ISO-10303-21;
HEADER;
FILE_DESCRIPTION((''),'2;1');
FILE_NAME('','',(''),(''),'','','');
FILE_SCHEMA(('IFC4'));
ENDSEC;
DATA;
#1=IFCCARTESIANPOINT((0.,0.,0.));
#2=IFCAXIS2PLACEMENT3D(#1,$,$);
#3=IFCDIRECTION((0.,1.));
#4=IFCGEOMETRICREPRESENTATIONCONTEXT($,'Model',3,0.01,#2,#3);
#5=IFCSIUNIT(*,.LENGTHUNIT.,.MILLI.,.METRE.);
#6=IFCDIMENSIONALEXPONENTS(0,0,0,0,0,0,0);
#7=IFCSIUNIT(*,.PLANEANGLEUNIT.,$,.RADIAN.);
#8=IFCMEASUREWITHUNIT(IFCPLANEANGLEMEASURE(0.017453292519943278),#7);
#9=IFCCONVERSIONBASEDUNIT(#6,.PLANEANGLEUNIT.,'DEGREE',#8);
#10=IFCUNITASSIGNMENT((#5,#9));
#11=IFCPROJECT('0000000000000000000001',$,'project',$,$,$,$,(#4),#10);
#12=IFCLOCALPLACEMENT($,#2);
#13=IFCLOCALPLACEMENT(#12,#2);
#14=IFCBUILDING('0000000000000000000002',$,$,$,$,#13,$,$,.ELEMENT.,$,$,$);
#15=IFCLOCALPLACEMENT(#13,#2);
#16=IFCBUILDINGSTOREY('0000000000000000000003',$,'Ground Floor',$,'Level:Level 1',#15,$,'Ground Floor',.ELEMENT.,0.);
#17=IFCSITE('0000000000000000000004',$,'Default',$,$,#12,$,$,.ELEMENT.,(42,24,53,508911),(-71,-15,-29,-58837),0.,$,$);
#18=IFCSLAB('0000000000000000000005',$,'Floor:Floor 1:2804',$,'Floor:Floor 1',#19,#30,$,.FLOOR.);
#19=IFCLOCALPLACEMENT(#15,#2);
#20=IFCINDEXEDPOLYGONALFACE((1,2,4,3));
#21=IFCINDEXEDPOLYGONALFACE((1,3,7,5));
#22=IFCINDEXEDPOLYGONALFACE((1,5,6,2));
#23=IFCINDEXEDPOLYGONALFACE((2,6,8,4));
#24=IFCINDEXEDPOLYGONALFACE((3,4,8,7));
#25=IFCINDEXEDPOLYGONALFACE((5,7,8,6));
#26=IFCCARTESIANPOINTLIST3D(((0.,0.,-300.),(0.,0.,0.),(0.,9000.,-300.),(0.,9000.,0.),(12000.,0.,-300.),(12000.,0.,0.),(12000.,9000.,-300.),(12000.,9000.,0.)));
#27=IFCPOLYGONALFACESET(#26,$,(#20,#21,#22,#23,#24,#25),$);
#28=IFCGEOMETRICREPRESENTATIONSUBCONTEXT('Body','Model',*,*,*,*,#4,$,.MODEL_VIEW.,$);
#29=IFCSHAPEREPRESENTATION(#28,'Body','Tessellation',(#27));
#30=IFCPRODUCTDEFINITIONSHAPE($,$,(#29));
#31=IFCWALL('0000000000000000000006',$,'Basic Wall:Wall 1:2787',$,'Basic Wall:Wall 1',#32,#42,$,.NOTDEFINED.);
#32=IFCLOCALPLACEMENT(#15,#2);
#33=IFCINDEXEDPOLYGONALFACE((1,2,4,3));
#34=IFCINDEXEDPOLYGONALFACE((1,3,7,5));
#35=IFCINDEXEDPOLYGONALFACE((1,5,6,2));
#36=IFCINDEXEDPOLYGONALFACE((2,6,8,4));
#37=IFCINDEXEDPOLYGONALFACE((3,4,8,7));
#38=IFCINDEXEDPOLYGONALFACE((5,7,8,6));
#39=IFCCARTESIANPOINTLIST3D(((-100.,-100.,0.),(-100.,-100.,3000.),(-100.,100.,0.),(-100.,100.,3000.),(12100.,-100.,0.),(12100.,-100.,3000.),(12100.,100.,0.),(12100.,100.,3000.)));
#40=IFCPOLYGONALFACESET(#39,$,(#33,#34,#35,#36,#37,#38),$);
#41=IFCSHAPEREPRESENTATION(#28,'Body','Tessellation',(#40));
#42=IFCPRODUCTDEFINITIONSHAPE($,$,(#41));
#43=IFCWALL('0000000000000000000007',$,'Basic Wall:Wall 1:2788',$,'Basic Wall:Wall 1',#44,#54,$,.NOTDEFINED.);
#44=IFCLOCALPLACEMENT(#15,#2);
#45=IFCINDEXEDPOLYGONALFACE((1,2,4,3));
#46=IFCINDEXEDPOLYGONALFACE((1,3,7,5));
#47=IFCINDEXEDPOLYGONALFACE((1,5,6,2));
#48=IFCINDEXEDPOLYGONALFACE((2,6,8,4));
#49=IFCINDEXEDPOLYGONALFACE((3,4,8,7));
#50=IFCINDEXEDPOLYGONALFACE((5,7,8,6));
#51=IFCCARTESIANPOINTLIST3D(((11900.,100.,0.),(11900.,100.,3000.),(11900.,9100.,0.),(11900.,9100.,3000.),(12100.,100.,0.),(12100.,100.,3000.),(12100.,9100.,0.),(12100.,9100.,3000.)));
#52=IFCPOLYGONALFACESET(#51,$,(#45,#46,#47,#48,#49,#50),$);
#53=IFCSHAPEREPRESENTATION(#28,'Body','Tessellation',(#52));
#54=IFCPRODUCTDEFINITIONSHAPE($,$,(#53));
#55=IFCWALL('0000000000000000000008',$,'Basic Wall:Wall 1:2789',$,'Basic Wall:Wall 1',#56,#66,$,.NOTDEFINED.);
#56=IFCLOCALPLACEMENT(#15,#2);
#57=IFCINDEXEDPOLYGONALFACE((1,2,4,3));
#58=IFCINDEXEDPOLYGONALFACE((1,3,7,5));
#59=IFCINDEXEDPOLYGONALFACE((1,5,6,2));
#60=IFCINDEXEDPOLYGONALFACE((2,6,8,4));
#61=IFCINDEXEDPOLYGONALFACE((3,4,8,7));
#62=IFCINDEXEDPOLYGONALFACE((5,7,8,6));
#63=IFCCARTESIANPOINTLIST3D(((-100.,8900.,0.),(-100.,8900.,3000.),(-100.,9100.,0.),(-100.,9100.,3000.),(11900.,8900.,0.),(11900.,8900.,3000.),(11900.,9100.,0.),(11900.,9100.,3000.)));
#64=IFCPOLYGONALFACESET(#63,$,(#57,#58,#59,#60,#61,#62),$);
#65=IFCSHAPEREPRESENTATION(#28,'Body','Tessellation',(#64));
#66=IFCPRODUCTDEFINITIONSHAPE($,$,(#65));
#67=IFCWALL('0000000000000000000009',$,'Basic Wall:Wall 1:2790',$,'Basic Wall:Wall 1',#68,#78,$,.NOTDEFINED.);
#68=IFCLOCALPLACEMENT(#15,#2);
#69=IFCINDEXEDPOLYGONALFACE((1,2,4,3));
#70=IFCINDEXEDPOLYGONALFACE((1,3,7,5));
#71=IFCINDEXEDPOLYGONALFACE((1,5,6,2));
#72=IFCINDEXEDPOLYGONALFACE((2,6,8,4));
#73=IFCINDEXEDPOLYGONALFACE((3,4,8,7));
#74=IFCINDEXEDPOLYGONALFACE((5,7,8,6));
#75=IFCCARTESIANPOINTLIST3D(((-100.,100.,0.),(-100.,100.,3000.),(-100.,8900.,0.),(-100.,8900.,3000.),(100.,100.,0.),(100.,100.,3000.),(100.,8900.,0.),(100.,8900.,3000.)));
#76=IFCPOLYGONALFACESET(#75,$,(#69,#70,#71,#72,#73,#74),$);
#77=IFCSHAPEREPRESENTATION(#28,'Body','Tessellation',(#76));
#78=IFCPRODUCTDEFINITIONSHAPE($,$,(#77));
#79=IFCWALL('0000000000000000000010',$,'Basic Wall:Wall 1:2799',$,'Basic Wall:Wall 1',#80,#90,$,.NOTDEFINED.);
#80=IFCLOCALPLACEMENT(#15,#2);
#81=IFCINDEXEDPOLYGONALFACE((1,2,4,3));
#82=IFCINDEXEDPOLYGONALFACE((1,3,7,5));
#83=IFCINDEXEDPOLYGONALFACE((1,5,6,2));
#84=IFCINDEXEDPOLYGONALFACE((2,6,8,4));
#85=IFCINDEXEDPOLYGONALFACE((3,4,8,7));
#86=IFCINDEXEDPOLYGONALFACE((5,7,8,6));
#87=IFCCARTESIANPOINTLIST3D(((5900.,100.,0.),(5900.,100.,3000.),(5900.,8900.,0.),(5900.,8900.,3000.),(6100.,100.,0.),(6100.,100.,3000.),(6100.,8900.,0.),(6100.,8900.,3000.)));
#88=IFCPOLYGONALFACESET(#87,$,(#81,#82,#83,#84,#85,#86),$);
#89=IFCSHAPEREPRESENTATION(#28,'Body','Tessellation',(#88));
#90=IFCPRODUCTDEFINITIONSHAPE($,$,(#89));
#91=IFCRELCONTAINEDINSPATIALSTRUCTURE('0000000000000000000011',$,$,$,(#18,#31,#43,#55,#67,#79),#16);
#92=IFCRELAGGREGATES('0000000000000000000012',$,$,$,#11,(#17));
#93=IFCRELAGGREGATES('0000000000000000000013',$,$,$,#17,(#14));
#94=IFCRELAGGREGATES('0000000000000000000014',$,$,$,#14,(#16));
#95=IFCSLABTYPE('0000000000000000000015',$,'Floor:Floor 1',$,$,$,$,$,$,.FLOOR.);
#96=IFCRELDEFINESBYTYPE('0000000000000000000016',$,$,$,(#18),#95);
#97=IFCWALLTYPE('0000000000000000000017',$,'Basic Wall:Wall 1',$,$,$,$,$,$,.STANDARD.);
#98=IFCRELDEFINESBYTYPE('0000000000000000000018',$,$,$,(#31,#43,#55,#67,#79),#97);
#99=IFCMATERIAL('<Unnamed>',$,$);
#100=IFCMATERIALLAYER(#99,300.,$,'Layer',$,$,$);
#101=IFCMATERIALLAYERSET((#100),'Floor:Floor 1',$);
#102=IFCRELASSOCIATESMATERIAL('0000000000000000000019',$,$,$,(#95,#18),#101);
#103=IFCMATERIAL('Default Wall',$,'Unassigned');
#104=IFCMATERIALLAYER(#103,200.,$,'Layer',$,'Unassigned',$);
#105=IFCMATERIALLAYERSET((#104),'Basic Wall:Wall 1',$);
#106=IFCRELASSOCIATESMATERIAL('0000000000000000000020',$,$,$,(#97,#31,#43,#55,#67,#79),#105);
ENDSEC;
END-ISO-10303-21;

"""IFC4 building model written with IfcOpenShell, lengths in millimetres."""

from ifc_helpers import new_model, entity, si_unit, converted_unit, direction, frame, frame_2d, origin, origin_2d_with_axis, place, context, subcontext, project, spatial, rectangle, extrude, material, layer, layer_set, layer_usage, type_object, element, save


model = new_model("IFC4")

# Units and contexts
model_context = context("Model", 3, precision=0.01, world=origin(), true_north=direction((0.0, 1.0)))
body_context = subcontext(model_context, "Body", "Model", "MODEL_VIEW")
ifc_project = project(units=[si_unit("LENGTHUNIT", "METRE", prefix="MILLI"), converted_unit("PLANEANGLEUNIT", "DEGREE", entity("IfcPlaneAngleMeasure", 0.017453292519943278), si_unit("PLANEANGLEUNIT", "RADIAN"), dimensions=[0, 0, 0, 0, 0, 0, 0])], contexts=[model_context])

# Site, building, storey
site_placement = place(None, origin())
site = spatial("IfcSite", under=ifc_project, at=site_placement, Name="Default", CompositionType="ELEMENT", RefLatitude=(42, 24, 53, 508911), RefLongitude=(-71, -15, -29, -58837), RefElevation=0.0)
building_placement = place(site_placement, origin())
building = spatial("IfcBuilding", under=site, at=building_placement, CompositionType="ELEMENT")
storey_placement = place(building_placement, origin())
storey = spatial("IfcBuildingStorey", under=building, at=storey_placement, Name="Ground Floor", ObjectType="Level:Level 1", LongName="Ground Floor", CompositionType="ELEMENT", Elevation=0.0)

# Slab
ifc_material_1 = material(Name="<Unnamed>")
ifc_layer_1 = layer(ifc_material_1, 300.0, Name="Layer")
ifc_layer_set_1 = layer_set([ifc_layer_1], Name="Floor:Floor 1")
ifc_layer_usage_1 = layer_usage(ifc_layer_set_1, "AXIS3", "POSITIVE", 0.0)
slab_type = type_object("IfcSlabType", Name="Floor:Floor 1", PredefinedType="FLOOR", material=ifc_layer_set_1)
slab_placement = place(storey_placement, origin())
element("IfcSlab", 1, at=slab_placement, inside=storey, type_object=slab_type, material=ifc_layer_usage_1, Name="Floor:Floor 1:2804", ObjectType="Floor:Floor 1", PredefinedType="FLOOR", context=body_context, shape_type="SweptSolid", body=[
    extrude(rectangle(XDim=9000.0, YDim=12000.0, at=origin_2d_with_axis()), frame((6000.0, 4500.0, 0.0), z_axis=(0.0, 0.0, -1.0), x_axis=(0.0, 1.0, 0.0)), (0.0, 0.0, 1.0), 300.0),
])

# Walls
ifc_material_2 = material(Name="Default Wall", Category="Unassigned")
ifc_layer_2 = layer(ifc_material_2, 200.0, Name="Layer", Category="Unassigned")
ifc_layer_set_2 = layer_set([ifc_layer_2], Name="Basic Wall:Wall 1")
ifc_layer_usage_2 = layer_usage(ifc_layer_set_2, "AXIS2", "NEGATIVE", 100.0)
wall_type = type_object("IfcWallType", Name="Basic Wall:Wall 1", PredefinedType="STANDARD", material=ifc_layer_set_2)
wall_1_placement = place(storey_placement, frame((-100.0, 0.0, 0.0)))
element("IfcWall", 2, at=wall_1_placement, inside=storey, type_object=wall_type, material=ifc_layer_usage_2, Name="Basic Wall:Wall 1:2787", ObjectType="Basic Wall:Wall 1", PredefinedType="NOTDEFINED", context=body_context, shape_type="SweptSolid", body=[
    extrude(rectangle(XDim=12200.0, YDim=200.0, at=frame_2d((6100.0, 0.0), x_axis=(-1.0, 0.0))), origin(), (0.0, 0.0, 1.0), 3000.0),
])
ifc_layer_usage_3 = layer_usage(ifc_layer_set_2, "AXIS2", "NEGATIVE", 100.0)
wall_2_placement = place(storey_placement, frame((12000.0, 100.0, 0.0), z_axis=(0.0, 0.0, 1.0), x_axis=(0.0, 1.0, 0.0)))
element("IfcWall", 3, at=wall_2_placement, inside=storey, type_object=wall_type, material=ifc_layer_usage_3, Name="Basic Wall:Wall 1:2788", ObjectType="Basic Wall:Wall 1", PredefinedType="NOTDEFINED", context=body_context, shape_type="SweptSolid", body=[
    extrude(rectangle(XDim=9000.0, YDim=200.0, at=frame_2d((4500.0, 0.0), x_axis=(-1.0, 0.0))), origin(), (0.0, 0.0, 1.0), 3000.0),
])
ifc_layer_usage_4 = layer_usage(ifc_layer_set_2, "AXIS2", "NEGATIVE", 100.0)
wall_3_placement = place(storey_placement, frame((11900.0, 9000.0, 0.0), z_axis=(0.0, 0.0, 1.0), x_axis=(-1.0, 0.0, 0.0)))
element("IfcWall", 4, at=wall_3_placement, inside=storey, type_object=wall_type, material=ifc_layer_usage_4, Name="Basic Wall:Wall 1:2789", ObjectType="Basic Wall:Wall 1", PredefinedType="NOTDEFINED", context=body_context, shape_type="SweptSolid", body=[
    extrude(rectangle(XDim=12000.0, YDim=200.0, at=frame_2d((6000.0, 0.0), x_axis=(-1.0, 0.0))), origin(), (0.0, 0.0, 1.0), 3000.0),
])
ifc_layer_usage_5 = layer_usage(ifc_layer_set_2, "AXIS2", "NEGATIVE", 100.0)
wall_4_placement = place(storey_placement, frame((0.0, 8900.0, 0.0), z_axis=(0.0, 0.0, 1.0), x_axis=(0.0, -1.0, 0.0)))
element("IfcWall", 5, at=wall_4_placement, inside=storey, type_object=wall_type, material=ifc_layer_usage_5, Name="Basic Wall:Wall 1:2790", ObjectType="Basic Wall:Wall 1", PredefinedType="NOTDEFINED", context=body_context, shape_type="SweptSolid", body=[
    extrude(rectangle(XDim=8800.0, YDim=200.0, at=frame_2d((4400.0, 0.0), x_axis=(-1.0, 0.0))), origin(), (0.0, 0.0, 1.0), 3000.0),
])
ifc_layer_usage_6 = layer_usage(ifc_layer_set_2, "AXIS2", "NEGATIVE", 100.0)
wall_5_placement = place(storey_placement, frame((6000.0, 100.0, 0.0), z_axis=(0.0, 0.0, 1.0), x_axis=(0.0, 1.0, 0.0)))
element("IfcWall", 6, at=wall_5_placement, inside=storey, type_object=wall_type, material=ifc_layer_usage_6, Name="Basic Wall:Wall 1:2799", ObjectType="Basic Wall:Wall 1", PredefinedType="NOTDEFINED", context=body_context, shape_type="SweptSolid", body=[
    extrude(rectangle(XDim=8800.0, YDim=200.0, at=frame_2d((4400.0, 0.0), x_axis=(-1.0, 0.0))), origin(), (0.0, 0.0, 1.0), 3000.0),
])

save(model, "model.ifc")
